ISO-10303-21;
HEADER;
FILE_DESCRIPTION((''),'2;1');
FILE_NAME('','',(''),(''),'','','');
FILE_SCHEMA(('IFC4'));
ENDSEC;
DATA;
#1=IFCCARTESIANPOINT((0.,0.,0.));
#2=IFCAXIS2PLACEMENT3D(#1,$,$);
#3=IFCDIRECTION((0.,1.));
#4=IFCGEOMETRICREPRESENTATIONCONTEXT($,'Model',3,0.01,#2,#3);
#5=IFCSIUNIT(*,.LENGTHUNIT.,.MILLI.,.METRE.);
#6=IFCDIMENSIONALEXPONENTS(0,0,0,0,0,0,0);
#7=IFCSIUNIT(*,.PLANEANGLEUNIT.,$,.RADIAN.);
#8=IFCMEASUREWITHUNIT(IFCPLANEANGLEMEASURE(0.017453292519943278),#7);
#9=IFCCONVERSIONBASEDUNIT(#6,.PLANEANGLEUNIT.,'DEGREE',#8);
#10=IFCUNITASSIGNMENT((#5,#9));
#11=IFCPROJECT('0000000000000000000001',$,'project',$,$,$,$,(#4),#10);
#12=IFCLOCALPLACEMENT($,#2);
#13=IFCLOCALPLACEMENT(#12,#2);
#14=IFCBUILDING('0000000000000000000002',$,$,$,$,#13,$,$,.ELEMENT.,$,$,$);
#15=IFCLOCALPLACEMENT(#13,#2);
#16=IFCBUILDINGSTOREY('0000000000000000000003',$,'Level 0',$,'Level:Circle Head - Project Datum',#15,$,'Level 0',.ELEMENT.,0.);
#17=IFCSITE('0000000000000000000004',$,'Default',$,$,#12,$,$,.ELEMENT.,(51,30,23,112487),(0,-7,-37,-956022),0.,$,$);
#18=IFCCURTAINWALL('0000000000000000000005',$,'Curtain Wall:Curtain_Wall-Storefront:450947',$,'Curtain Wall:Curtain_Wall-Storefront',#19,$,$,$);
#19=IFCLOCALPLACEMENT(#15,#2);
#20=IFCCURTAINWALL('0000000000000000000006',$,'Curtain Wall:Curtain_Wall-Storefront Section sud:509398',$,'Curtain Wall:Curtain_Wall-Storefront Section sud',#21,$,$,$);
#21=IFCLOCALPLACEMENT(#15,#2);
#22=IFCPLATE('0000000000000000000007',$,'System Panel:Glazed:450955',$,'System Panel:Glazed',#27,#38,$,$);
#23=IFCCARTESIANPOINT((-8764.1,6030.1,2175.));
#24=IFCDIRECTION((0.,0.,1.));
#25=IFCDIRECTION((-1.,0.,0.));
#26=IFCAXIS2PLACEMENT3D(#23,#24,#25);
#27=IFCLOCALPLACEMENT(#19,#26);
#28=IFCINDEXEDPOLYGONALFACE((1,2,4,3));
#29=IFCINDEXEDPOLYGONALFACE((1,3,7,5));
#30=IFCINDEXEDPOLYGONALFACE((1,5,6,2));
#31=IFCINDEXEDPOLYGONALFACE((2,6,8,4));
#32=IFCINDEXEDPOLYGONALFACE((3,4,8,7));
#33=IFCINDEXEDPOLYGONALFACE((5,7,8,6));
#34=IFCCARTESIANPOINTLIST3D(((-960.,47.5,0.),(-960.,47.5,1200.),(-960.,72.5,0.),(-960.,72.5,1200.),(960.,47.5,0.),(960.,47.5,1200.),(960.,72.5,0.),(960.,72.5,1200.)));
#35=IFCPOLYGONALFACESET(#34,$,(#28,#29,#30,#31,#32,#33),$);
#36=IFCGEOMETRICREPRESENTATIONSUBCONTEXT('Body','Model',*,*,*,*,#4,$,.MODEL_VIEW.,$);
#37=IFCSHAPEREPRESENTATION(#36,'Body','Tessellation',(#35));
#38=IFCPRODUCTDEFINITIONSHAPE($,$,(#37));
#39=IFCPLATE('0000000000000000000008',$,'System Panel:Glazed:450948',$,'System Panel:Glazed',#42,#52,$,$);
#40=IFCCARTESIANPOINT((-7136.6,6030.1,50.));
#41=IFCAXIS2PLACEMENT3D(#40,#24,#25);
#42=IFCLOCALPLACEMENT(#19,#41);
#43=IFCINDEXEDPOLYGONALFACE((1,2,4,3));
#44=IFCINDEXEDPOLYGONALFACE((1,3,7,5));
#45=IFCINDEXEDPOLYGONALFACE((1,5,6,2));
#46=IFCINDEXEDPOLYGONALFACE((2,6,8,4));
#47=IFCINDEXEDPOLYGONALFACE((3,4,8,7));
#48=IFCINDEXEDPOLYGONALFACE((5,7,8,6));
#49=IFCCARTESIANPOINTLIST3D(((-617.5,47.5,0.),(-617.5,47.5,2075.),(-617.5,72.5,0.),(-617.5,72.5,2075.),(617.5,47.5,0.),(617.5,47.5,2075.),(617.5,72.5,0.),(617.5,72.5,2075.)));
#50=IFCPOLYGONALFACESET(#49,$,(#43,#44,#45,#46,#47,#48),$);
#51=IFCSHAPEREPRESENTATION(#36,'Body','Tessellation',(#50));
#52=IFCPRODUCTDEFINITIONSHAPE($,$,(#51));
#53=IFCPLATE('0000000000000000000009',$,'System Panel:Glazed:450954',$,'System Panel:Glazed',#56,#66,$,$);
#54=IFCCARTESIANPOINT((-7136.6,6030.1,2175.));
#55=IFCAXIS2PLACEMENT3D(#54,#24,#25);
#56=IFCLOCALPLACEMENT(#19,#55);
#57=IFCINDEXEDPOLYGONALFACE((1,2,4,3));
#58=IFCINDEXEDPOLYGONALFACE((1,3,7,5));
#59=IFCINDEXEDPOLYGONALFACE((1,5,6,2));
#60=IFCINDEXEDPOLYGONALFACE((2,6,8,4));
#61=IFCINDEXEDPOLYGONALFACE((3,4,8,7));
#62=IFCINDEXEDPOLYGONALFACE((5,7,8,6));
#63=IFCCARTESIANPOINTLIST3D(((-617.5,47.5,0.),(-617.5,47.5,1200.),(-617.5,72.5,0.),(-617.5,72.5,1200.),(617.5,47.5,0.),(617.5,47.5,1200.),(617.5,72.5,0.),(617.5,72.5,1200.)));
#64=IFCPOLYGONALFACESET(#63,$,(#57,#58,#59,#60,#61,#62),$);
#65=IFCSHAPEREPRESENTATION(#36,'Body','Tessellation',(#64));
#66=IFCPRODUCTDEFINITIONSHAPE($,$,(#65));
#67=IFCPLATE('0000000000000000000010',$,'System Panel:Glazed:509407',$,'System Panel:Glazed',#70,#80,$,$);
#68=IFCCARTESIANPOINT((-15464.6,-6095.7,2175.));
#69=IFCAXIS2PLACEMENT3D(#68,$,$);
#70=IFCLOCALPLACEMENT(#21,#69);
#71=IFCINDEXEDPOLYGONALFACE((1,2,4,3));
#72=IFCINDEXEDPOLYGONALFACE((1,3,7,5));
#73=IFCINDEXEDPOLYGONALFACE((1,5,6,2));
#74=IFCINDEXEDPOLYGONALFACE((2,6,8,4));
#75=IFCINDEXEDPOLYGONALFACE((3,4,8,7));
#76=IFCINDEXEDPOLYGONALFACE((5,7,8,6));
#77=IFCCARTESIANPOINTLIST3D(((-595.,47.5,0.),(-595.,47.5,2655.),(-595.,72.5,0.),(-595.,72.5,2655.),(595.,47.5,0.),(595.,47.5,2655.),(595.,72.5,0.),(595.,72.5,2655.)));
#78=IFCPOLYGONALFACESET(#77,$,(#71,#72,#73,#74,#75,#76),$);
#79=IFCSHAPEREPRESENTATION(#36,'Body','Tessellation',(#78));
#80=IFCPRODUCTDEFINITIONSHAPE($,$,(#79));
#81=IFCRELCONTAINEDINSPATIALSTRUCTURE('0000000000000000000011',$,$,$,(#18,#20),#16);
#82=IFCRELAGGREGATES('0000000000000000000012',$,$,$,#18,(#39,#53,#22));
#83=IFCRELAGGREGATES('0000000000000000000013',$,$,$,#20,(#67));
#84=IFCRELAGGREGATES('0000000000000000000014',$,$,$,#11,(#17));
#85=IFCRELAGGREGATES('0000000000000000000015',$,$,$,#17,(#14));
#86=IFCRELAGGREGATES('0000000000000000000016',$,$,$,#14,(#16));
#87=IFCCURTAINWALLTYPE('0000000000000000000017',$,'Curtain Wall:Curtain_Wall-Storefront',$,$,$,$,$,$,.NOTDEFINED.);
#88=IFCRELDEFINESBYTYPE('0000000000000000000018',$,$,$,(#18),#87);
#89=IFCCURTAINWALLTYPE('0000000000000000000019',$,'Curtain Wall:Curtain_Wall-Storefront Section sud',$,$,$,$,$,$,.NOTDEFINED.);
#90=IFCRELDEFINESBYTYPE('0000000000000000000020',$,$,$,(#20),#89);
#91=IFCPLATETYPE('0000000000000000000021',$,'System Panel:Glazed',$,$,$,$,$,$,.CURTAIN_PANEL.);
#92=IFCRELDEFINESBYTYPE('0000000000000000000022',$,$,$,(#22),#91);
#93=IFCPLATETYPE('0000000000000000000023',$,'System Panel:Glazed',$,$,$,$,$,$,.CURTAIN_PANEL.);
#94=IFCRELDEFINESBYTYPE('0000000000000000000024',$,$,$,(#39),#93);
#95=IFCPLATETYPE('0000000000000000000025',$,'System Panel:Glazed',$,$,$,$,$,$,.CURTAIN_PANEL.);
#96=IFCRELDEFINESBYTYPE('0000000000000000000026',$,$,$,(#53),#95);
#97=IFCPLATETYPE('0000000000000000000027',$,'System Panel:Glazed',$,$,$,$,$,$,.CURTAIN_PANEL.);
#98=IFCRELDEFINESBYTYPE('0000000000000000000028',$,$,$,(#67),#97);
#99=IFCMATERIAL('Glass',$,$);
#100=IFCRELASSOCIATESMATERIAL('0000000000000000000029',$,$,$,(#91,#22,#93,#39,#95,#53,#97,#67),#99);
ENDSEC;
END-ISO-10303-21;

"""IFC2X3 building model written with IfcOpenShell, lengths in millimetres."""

from ifc_helpers import new_model, entity, si_unit, converted_unit, direction, frame, frame_2d, origin, origin_2d_with_axis, place, context, subcontext, project, spatial, rectangle, extrude, source, transform, mapped, material, type_object, type_shapes, element, aggregate, save


model = new_model("IFC2X3")

# Units and contexts
model_context = context("Model", 3, precision=0.01, world=origin(), true_north=direction((0.0, 1.0)))
body_context = subcontext(model_context, "Body", "Model", "MODEL_VIEW")
ifc_project = project(units=[si_unit("LENGTHUNIT", "METRE", prefix="MILLI"), converted_unit("PLANEANGLEUNIT", "DEGREE", entity("IfcPlaneAngleMeasure", 0.017453292519943278), si_unit("PLANEANGLEUNIT", "RADIAN"), dimensions=[0, 0, 0, 0, 0, 0, 0])], contexts=[model_context])

# Site, building, storey
site_placement = place(None, origin())
site = spatial("IfcSite", under=ifc_project, at=site_placement, Name="Default", CompositionType="ELEMENT", RefLatitude=(51, 30, 23, 112487), RefLongitude=(0, -7, -37, -956022), RefElevation=0.0)
building_placement = place(site_placement, origin())
building = spatial("IfcBuilding", under=site, at=building_placement, CompositionType="ELEMENT")
storey_placement = place(building_placement, origin())
storey = spatial("IfcBuildingStorey", under=building, at=storey_placement, Name="Level 0", ObjectType="Level:Circle Head - Project Datum", LongName="Level 0", CompositionType="ELEMENT", Elevation=0.0)

# Curtain walls
curtain_wall_type_1 = type_object("IfcCurtainWallType", Name="Curtain Wall:Curtain_Wall-Storefront", PredefinedType="NOTDEFINED")
curtain_wall_1_placement = place(storey_placement, origin())
curtain_wall_1 = element("IfcCurtainWall", 1, at=curtain_wall_1_placement, inside=storey, type_object=curtain_wall_type_1, Name="Curtain Wall:Curtain_Wall-Storefront:450947", ObjectType="Curtain Wall:Curtain_Wall-Storefront")
curtain_wall_type_2 = type_object("IfcCurtainWallType", Name="Curtain Wall:Curtain_Wall-Storefront Section sud", PredefinedType="NOTDEFINED")
curtain_wall_2_placement = place(storey_placement, origin())
curtain_wall_2 = element("IfcCurtainWall", 2, at=curtain_wall_2_placement, inside=storey, type_object=curtain_wall_type_2, Name="Curtain Wall:Curtain_Wall-Storefront Section sud:509398", ObjectType="Curtain Wall:Curtain_Wall-Storefront Section sud")

# Plates
ifc_material_1 = material(Name="Glass")
plate_type_1 = type_object("IfcPlateType", Name="System Panel:Glazed", PredefinedType="CURTAIN_PANEL", material=ifc_material_1)
shared_shape_1 = source(origin(), body_context, "Body", "SweptSolid", [
    extrude(rectangle(XDim=25.0, YDim=1920.0, at=origin_2d_with_axis()), frame((0.0, 60.0, 0.0), z_axis=(0.0, 0.0, 1.0), x_axis=(0.0, 1.0, 0.0)), (0.0, 0.0, 1.0), 1200.0),
])
type_shapes(plate_type_1, [shared_shape_1])
plate_1_placement = place(curtain_wall_1_placement, frame((-8764.1, 6030.1, 2175.0), z_axis=(0.0, 0.0, 1.0), x_axis=(-1.0, 0.0, 0.0)))
plate_1 = element("IfcPlate", 3, at=plate_1_placement, type_object=plate_type_1, material=ifc_material_1, Name="System Panel:Glazed:450955", ObjectType="System Panel:Glazed", context=body_context, shape_type="MappedRepresentation", body=[
    mapped(shared_shape_1, transform((0.0, 0.0, 0.0), scale=1.0)),
])
plate_type_2 = type_object("IfcPlateType", Name="System Panel:Glazed", PredefinedType="CURTAIN_PANEL", material=ifc_material_1)
shared_shape_2 = source(origin(), body_context, "Body", "SweptSolid", [
    extrude(rectangle(XDim=25.0, YDim=1235.0, at=origin_2d_with_axis()), frame((0.0, 60.0, 0.0), z_axis=(0.0, 0.0, 1.0), x_axis=(0.0, 1.0, 0.0)), (0.0, 0.0, 1.0), 2075.0),
])
type_shapes(plate_type_2, [shared_shape_2])
plate_2_placement = place(curtain_wall_1_placement, frame((-7136.6, 6030.1, 50.0), z_axis=(0.0, 0.0, 1.0), x_axis=(-1.0, 0.0, 0.0)))
plate_2 = element("IfcPlate", 4, at=plate_2_placement, type_object=plate_type_2, material=ifc_material_1, Name="System Panel:Glazed:450948", ObjectType="System Panel:Glazed", context=body_context, shape_type="MappedRepresentation", body=[
    mapped(shared_shape_2, transform((0.0, 0.0, 0.0), scale=1.0)),
])
plate_type_3 = type_object("IfcPlateType", Name="System Panel:Glazed", PredefinedType="CURTAIN_PANEL", material=ifc_material_1)
shared_shape_3 = source(origin(), body_context, "Body", "SweptSolid", [
    extrude(rectangle(XDim=25.0, YDim=1235.0, at=origin_2d_with_axis()), frame((0.0, 60.0, 0.0), z_axis=(0.0, 0.0, 1.0), x_axis=(0.0, 1.0, 0.0)), (0.0, 0.0, 1.0), 1200.0),
])
type_shapes(plate_type_3, [shared_shape_3])
plate_3_placement = place(curtain_wall_1_placement, frame((-7136.6, 6030.1, 2175.0), z_axis=(0.0, 0.0, 1.0), x_axis=(-1.0, 0.0, 0.0)))
plate_3 = element("IfcPlate", 5, at=plate_3_placement, type_object=plate_type_3, material=ifc_material_1, Name="System Panel:Glazed:450954", ObjectType="System Panel:Glazed", context=body_context, shape_type="MappedRepresentation", body=[
    mapped(shared_shape_3, transform((0.0, 0.0, 0.0), scale=1.0)),
])
aggregate(curtain_wall_1, [plate_2, plate_3, plate_1])
plate_type_4 = type_object("IfcPlateType", Name="System Panel:Glazed", PredefinedType="CURTAIN_PANEL", material=ifc_material_1)
shared_shape_4 = source(origin(), body_context, "Body", "SweptSolid", [
    extrude(rectangle(XDim=25.0, YDim=1190.0, at=frame_2d((0.0, 0.0), x_axis=(1.0, 0.0))), frame((0.0, 60.0, 0.0), z_axis=(0.0, 0.0, 1.0), x_axis=(0.0, 1.0, 0.0)), (0.0, 0.0, 1.0), 2655.0),
])
type_shapes(plate_type_4, [shared_shape_4])
plate_4_placement = place(curtain_wall_2_placement, frame((-15464.6, -6095.7, 2175.0)))
plate_4 = element("IfcPlate", 6, at=plate_4_placement, type_object=plate_type_4, material=ifc_material_1, Name="System Panel:Glazed:509407", ObjectType="System Panel:Glazed", context=body_context, shape_type="MappedRepresentation", body=[
    mapped(shared_shape_4, transform((0.0, 0.0, 0.0), scale=1.0)),
])
aggregate(curtain_wall_2, [plate_4])

save(model, "model.ifc")
